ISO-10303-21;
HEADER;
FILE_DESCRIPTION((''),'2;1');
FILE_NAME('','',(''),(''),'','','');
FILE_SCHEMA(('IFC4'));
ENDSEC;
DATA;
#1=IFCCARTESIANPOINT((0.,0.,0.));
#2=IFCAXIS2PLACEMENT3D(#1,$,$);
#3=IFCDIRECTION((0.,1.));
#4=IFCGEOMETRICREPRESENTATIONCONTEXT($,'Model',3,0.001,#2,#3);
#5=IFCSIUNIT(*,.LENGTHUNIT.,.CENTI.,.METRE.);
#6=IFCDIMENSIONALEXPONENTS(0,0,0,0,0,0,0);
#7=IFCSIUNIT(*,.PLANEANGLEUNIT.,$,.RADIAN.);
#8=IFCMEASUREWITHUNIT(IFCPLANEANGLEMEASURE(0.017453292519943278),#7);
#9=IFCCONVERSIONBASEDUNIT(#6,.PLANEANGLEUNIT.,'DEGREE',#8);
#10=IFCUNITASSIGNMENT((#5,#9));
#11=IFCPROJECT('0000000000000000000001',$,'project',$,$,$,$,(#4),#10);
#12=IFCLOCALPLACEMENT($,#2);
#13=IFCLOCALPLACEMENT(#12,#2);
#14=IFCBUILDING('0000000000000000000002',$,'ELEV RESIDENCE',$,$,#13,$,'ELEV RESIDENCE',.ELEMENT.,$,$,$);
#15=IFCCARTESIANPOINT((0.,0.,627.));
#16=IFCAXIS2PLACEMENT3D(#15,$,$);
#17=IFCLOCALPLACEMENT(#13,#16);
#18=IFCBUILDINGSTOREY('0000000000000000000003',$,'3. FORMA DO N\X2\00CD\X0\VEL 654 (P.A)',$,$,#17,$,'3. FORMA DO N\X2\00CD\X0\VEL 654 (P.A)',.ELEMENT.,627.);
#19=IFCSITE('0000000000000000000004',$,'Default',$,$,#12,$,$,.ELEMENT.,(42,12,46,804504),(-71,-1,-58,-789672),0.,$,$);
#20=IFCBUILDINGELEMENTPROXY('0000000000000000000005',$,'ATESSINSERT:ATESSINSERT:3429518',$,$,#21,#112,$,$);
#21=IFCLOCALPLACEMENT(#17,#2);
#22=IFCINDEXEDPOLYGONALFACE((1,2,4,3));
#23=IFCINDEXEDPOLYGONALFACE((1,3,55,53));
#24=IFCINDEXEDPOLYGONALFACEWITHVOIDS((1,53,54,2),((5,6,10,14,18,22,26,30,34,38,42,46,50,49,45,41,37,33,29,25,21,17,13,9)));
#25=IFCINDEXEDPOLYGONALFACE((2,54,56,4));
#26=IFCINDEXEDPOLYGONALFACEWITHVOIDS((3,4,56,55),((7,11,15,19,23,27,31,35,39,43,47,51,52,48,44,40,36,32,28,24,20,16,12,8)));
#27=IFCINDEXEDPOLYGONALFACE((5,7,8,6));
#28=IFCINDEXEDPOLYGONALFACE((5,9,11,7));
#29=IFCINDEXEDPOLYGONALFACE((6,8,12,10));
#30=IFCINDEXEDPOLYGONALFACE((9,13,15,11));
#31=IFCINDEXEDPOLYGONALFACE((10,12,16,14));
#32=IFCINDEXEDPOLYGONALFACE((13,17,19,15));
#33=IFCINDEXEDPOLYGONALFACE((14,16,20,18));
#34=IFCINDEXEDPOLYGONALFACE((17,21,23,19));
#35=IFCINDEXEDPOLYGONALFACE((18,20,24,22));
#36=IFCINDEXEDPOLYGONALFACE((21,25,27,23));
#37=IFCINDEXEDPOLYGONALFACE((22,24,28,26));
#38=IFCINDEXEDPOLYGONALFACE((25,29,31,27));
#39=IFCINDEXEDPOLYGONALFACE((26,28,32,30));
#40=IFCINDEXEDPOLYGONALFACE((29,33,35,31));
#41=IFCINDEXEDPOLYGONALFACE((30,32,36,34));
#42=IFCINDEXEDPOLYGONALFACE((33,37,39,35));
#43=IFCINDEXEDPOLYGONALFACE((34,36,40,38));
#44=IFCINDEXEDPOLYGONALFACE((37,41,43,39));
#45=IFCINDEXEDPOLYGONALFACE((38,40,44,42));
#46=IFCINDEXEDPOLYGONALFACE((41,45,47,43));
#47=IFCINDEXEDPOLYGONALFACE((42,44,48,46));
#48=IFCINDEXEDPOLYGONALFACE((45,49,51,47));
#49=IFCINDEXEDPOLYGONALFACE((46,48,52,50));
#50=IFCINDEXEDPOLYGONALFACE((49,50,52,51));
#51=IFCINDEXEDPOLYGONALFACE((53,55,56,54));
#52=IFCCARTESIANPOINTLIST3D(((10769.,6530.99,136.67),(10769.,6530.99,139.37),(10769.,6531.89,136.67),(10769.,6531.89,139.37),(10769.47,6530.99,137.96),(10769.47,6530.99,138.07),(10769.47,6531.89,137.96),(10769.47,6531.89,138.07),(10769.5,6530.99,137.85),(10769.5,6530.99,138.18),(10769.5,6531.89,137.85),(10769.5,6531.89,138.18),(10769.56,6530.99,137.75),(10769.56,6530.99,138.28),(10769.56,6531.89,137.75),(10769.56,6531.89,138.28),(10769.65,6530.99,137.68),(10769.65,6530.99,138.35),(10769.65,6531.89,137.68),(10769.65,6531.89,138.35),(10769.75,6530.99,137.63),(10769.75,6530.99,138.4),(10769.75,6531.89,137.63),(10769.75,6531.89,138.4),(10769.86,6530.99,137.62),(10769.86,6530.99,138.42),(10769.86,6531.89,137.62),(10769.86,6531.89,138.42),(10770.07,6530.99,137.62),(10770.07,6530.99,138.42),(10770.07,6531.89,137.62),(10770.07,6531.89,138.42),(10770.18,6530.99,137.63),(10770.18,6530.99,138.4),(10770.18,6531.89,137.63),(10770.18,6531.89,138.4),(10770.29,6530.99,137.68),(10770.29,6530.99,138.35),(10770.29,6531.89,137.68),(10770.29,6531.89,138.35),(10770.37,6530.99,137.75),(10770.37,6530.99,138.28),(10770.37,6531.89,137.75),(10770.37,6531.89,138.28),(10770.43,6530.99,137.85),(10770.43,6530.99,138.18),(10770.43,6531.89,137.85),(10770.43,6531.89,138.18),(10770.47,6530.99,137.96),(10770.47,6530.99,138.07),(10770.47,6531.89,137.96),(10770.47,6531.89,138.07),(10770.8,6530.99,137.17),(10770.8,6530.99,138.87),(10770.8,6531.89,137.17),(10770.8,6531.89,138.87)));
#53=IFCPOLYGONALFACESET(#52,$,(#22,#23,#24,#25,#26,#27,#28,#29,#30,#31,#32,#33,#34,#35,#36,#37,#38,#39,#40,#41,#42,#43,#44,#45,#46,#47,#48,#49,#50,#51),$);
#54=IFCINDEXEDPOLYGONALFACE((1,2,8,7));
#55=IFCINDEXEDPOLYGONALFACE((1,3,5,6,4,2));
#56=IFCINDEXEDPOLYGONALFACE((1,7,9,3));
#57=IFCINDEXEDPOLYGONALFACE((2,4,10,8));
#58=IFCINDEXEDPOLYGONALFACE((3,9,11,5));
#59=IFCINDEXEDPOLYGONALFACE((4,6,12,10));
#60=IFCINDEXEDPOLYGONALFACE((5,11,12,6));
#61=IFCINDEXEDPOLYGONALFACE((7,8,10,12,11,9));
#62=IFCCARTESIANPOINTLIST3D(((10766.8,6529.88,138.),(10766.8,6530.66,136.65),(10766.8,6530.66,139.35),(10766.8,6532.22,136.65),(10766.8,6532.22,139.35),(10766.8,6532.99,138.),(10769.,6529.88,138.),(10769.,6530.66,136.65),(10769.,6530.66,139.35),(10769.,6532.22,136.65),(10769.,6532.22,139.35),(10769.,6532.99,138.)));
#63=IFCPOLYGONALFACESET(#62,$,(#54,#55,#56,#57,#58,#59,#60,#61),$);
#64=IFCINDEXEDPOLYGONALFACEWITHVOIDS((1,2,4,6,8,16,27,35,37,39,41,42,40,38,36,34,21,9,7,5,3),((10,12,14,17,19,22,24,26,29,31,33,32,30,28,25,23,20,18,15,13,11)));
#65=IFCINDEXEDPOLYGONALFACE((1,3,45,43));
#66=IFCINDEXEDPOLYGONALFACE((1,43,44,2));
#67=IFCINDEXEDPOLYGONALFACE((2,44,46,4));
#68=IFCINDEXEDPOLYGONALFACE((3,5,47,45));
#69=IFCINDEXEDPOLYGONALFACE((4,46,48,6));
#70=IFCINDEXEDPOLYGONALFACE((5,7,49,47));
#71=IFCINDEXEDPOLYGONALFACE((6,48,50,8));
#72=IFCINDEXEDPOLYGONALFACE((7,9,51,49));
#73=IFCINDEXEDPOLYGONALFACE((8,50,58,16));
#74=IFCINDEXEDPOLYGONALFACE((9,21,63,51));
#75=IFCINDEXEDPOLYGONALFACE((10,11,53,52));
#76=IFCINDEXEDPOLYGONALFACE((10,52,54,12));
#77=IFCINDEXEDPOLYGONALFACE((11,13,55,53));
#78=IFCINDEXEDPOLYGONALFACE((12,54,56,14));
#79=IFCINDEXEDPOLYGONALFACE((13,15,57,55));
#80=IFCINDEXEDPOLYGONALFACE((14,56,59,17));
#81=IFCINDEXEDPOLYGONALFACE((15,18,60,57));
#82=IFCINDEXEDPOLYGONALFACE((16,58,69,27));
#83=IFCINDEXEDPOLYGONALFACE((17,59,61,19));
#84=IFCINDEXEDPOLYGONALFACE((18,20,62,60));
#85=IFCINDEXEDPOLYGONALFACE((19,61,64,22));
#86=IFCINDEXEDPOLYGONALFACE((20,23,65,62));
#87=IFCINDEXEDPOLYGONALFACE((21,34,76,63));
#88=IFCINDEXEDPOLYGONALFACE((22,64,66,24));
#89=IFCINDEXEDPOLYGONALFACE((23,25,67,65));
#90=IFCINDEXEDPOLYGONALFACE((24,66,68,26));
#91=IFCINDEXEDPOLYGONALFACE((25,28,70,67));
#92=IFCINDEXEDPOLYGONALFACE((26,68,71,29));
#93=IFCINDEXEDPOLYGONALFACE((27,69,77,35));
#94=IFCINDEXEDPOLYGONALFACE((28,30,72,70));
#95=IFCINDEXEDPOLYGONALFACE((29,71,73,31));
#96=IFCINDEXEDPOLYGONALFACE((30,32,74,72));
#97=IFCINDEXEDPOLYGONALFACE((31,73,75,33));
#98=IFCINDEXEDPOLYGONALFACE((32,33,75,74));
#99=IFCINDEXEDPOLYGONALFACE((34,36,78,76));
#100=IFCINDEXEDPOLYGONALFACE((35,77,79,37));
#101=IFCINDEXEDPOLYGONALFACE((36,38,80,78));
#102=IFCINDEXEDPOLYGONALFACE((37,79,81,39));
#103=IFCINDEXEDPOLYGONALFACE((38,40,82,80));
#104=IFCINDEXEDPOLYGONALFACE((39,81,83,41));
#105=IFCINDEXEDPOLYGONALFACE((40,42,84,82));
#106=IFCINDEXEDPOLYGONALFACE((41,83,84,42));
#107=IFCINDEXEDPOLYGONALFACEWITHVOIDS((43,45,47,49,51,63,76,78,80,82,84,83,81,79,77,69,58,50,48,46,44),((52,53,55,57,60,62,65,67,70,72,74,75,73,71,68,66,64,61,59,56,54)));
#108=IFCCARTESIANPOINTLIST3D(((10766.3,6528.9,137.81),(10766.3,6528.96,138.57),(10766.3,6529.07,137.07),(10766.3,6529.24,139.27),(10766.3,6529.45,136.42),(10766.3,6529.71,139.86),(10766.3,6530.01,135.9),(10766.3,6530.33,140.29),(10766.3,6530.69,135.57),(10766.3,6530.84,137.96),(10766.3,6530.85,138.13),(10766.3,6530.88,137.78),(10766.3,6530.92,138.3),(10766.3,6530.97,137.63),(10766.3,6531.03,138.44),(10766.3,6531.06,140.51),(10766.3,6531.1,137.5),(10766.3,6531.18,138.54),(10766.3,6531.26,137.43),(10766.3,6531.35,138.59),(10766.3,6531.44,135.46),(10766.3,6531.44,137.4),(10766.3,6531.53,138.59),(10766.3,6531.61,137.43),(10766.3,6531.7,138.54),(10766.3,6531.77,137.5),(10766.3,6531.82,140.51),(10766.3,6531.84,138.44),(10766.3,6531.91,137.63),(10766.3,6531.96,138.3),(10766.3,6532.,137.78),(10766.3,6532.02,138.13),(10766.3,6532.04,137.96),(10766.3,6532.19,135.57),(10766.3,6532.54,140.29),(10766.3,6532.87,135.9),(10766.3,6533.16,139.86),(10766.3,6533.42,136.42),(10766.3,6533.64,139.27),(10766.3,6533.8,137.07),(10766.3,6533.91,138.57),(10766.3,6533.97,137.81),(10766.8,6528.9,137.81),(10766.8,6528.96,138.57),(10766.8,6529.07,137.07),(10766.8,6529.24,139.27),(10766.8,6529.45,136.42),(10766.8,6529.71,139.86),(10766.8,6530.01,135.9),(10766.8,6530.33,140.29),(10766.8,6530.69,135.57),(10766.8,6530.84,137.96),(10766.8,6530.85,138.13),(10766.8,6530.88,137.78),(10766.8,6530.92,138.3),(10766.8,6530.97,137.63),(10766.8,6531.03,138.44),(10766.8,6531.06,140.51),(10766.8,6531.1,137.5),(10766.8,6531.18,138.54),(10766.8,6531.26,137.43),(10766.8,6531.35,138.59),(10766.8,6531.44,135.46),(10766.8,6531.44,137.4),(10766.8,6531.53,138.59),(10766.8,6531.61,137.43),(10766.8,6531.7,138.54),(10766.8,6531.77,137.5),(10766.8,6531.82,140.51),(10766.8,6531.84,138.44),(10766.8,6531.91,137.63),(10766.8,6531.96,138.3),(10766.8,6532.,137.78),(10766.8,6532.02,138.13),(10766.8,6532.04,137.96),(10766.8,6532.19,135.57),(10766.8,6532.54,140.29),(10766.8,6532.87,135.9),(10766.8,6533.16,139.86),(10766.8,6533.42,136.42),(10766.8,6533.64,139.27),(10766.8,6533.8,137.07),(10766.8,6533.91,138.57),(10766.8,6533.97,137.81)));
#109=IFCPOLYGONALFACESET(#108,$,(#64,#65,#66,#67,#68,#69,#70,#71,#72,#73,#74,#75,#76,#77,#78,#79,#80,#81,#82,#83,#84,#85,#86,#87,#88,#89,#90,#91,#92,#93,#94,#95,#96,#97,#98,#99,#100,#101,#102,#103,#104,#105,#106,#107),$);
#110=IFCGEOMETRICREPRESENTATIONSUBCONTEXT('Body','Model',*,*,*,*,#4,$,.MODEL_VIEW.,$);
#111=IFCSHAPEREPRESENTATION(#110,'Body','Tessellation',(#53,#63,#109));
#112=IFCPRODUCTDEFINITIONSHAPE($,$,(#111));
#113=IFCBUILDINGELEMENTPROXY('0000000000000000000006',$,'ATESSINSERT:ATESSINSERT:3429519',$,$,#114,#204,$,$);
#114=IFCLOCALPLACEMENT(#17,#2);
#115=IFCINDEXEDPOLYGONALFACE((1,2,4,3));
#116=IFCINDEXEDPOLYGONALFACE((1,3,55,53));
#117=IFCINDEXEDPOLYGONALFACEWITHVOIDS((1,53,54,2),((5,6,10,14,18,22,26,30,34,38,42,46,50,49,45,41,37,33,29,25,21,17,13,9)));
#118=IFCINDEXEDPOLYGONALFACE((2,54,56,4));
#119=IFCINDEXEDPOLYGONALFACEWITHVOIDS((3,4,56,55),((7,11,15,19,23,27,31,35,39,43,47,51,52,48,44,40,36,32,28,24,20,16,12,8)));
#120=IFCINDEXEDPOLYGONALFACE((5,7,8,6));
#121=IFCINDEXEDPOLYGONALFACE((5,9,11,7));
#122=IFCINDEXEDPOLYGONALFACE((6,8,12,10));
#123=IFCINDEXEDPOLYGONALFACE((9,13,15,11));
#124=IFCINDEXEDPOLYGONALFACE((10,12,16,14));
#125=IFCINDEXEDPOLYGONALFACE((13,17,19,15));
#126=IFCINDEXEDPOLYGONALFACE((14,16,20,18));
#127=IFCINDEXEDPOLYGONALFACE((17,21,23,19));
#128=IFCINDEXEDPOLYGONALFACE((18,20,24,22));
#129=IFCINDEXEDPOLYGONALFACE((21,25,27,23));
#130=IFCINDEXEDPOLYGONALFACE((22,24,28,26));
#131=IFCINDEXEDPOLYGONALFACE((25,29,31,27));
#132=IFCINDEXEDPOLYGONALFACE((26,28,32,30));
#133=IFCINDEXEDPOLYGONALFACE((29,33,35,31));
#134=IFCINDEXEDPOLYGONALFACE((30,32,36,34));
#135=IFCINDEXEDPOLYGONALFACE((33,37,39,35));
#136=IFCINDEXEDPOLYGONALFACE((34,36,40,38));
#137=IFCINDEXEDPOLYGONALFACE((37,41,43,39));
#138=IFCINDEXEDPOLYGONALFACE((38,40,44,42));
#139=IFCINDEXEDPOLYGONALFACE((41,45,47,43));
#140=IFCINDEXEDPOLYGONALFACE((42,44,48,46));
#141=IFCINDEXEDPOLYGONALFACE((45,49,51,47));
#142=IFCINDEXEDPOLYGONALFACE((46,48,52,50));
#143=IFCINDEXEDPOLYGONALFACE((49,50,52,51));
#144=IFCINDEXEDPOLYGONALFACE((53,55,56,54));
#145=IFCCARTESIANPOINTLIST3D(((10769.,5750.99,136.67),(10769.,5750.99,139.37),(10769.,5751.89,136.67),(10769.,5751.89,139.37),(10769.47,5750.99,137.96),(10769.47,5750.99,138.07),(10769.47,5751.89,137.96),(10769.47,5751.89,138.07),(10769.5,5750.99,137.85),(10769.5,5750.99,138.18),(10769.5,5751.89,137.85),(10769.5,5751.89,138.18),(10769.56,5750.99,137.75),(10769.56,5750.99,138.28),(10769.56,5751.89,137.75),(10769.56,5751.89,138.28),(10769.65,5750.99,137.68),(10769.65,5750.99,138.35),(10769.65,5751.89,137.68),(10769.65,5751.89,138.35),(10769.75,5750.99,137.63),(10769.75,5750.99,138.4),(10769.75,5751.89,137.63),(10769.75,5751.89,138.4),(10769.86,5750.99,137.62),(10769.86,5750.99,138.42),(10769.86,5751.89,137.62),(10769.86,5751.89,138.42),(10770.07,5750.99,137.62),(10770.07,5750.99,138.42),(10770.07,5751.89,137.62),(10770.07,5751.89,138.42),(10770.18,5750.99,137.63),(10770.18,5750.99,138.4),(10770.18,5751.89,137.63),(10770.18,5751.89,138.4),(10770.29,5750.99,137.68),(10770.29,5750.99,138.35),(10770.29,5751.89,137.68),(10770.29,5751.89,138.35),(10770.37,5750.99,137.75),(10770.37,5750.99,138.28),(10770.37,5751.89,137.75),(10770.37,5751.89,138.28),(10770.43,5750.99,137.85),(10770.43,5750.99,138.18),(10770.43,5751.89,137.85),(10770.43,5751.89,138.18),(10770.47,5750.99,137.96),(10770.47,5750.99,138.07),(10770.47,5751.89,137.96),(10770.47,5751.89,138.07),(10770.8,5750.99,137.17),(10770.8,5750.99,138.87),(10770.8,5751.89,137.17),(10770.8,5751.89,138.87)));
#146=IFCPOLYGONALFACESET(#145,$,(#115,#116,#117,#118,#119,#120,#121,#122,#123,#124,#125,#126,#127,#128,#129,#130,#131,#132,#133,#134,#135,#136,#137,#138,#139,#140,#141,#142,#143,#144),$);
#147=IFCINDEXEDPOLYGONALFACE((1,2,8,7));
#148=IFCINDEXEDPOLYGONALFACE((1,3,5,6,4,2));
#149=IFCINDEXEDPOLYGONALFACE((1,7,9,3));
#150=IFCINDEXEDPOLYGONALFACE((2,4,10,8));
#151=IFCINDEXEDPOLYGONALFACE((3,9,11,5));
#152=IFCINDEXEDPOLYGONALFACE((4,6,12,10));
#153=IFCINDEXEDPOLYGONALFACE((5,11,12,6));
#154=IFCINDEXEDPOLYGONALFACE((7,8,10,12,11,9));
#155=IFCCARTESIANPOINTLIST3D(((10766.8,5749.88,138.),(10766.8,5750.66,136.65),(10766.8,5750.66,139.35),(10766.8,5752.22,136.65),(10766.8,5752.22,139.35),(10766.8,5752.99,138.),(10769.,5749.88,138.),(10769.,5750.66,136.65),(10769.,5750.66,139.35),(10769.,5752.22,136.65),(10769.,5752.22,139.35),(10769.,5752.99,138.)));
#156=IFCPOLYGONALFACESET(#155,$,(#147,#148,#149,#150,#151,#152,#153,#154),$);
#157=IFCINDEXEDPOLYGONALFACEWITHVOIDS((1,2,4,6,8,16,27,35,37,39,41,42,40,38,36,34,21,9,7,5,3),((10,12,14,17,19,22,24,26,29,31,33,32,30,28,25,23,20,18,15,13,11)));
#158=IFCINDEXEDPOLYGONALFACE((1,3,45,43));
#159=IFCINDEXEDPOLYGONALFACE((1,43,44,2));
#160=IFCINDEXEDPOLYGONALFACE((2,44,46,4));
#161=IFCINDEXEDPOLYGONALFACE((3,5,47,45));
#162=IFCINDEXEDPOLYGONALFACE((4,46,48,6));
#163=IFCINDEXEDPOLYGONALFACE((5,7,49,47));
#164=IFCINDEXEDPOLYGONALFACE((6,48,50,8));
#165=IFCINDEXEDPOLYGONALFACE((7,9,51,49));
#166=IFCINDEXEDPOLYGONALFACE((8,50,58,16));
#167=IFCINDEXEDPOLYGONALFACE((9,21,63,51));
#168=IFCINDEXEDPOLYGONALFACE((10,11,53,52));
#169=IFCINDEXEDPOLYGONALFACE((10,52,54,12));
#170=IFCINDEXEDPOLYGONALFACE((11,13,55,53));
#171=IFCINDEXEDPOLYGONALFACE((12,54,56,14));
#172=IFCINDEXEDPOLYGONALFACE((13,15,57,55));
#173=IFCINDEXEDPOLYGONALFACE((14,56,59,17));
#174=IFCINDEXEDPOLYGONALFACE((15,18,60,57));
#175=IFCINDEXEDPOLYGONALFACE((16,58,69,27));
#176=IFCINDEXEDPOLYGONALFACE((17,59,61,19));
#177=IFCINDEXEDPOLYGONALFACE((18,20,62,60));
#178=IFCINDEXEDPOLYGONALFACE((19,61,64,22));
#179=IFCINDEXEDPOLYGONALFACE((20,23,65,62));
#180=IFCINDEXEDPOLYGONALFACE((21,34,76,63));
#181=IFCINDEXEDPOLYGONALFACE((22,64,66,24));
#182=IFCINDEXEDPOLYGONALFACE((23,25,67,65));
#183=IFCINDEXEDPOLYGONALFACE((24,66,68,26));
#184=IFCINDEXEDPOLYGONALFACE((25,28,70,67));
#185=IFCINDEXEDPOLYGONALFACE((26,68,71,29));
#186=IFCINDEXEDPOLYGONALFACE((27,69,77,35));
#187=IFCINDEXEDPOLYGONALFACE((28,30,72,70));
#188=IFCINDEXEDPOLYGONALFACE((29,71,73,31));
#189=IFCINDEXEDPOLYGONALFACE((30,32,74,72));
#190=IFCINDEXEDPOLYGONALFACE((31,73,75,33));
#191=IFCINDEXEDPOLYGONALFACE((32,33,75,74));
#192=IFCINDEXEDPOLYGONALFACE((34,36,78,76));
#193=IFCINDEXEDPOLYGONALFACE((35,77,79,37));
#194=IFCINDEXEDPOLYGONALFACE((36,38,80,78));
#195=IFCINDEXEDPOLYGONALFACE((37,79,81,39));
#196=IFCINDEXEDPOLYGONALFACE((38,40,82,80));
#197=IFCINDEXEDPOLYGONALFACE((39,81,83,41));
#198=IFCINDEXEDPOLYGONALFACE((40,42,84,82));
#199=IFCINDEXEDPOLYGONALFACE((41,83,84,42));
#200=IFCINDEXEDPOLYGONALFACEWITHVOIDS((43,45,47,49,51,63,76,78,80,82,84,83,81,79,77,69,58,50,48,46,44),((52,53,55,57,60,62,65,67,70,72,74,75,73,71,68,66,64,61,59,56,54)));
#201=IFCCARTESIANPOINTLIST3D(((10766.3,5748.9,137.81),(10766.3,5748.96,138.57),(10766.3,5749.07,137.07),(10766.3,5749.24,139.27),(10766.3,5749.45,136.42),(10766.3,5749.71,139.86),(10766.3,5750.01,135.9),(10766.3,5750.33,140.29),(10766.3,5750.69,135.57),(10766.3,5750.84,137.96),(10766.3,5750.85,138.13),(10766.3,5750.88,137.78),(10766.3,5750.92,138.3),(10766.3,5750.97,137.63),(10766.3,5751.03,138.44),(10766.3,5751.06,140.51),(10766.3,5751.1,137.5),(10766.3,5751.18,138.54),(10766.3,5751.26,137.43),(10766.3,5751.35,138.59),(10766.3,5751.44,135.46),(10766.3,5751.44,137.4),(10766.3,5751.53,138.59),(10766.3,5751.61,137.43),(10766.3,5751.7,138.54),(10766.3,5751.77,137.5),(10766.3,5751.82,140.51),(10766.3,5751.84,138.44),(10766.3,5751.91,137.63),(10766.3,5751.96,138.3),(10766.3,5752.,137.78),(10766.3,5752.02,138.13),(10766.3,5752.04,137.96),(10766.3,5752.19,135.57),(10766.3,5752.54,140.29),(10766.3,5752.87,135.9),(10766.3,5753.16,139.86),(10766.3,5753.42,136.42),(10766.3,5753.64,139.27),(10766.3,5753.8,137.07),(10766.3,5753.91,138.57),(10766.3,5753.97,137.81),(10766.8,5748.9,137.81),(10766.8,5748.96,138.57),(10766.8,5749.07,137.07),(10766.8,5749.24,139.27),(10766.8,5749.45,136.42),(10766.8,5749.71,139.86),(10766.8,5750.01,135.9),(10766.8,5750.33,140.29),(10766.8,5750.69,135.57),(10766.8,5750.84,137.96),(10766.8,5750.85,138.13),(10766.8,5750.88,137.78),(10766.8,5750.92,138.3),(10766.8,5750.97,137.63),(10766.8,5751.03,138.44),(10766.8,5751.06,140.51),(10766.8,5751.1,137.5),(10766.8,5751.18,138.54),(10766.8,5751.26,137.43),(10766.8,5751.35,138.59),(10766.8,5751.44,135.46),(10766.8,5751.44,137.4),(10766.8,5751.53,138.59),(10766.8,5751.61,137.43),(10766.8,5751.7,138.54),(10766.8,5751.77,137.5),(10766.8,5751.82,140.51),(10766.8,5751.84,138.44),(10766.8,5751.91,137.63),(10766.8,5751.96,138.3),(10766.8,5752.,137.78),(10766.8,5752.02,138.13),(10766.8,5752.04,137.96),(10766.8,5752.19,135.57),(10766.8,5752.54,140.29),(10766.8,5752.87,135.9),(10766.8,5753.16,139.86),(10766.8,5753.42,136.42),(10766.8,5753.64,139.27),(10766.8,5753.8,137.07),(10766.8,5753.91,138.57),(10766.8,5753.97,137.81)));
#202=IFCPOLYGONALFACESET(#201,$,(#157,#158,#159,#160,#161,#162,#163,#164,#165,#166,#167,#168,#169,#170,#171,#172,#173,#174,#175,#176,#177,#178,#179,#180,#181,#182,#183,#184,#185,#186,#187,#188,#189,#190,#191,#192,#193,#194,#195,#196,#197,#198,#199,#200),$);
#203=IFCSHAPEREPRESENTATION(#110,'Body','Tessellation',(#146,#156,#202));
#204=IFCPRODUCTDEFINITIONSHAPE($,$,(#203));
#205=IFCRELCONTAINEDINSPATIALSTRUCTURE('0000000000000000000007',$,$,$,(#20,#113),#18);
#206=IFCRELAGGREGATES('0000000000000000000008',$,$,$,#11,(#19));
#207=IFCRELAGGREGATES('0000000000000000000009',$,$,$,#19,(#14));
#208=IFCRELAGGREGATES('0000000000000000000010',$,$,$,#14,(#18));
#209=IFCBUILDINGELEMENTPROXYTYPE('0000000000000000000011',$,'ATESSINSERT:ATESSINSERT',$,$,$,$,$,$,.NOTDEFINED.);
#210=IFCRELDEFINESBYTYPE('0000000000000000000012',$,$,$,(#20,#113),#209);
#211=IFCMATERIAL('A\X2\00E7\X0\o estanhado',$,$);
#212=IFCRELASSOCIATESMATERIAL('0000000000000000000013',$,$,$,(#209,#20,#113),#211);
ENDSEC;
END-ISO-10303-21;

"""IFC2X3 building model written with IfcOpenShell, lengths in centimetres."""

from ifc_helpers import new_model, entity, si_unit, converted_unit, direction, frame, frame_2d, origin, place, context, subcontext, project, spatial, polyline, circle_curve, parameter, trimmed, segment, composite_curve, hollow_circle, outline, extrude, source, transform, mapped, material, type_object, type_shapes, element, save


model = new_model("IFC2X3")

# Units and contexts
model_context = context("Model", 3, precision=0.001, world=origin(), true_north=direction((0.0, 1.0)))
body_context = subcontext(model_context, "Body", "Model", "MODEL_VIEW")
ifc_project = project(units=[si_unit("LENGTHUNIT", "METRE", prefix="CENTI"), converted_unit("PLANEANGLEUNIT", "DEGREE", entity("IfcPlaneAngleMeasure", 0.017453292519943278), si_unit("PLANEANGLEUNIT", "RADIAN"), dimensions=[0, 0, 0, 0, 0, 0, 0])], contexts=[model_context])

# Site, building, storey
site_placement = place(None, origin())
site = spatial("IfcSite", under=ifc_project, at=site_placement, Name="Default", CompositionType="ELEMENT", RefLatitude=(42, 12, 46, 804504), RefLongitude=(-71, -1, -58, -789672), RefElevation=0.0)
building_placement = place(site_placement, origin())
building = spatial("IfcBuilding", under=site, at=building_placement, Name="ELEV RESIDENCE", LongName="ELEV RESIDENCE", CompositionType="ELEMENT")
storey_placement = place(building_placement, frame((0.0, 0.0, 627.0)))
storey = spatial("IfcBuildingStorey", under=building, at=storey_placement, Name="3. FORMA DO NÍVEL 654 (P.A)", LongName="3. FORMA DO NÍVEL 654 (P.A)", CompositionType="ELEMENT", Elevation=627.0)

# Building element proxies
ifc_material_1 = material(Name="Aço estanhado")
building_element_proxy_type_1 = type_object("IfcBuildingElementProxyType", Name="ATESSINSERT:ATESSINSERT", PredefinedType="NOTDEFINED", material=ifc_material_1)
shared_shape_1 = source(origin(), body_context, "Body", "SweptSolid", [
    extrude(outline(polyline([(-1.35, -0.9), (1.35, -0.9), (0.85, 0.9), (-0.85, 0.9), (-1.35, -0.9)]), holes=[composite_curve([segment(trimmed(circle_curve(frame_2d((0.0, 0.17), x_axis=(1.0, 0.0)), 0.4), [parameter(0.0)], [parameter(180.0)], True, "PARAMETER"), False, "CONTINUOUS"), segment(polyline([(0.4, 0.17), (0.4, -0.03)]), True, "CONTINUOUS"), segment(trimmed(circle_curve(frame_2d((0.0, -0.03), x_axis=(1.0, 0.0)), 0.4), [parameter(180.0)], [parameter(0.0)], True, "PARAMETER"), False, "CONTINUOUS"), segment(polyline([(-0.4, -0.03), (-0.4, 0.17)]), True, "CONTINUOUS")], self_intersect=False)]), frame((-1.4, -0.45, 30.02), z_axis=(0.0, 1.0, 0.0), x_axis=(0.0, 0.0, 1.0)), (0.0, 0.0, 1.0), 0.9),
    extrude(outline(polyline([(-0.78, -1.35), (0.78, -1.35), (1.56, 0.0), (0.78, 1.35), (-0.78, 1.35), (-1.56, 0.0), (-0.78, -1.35)])), frame((-4.5, 0.0, 30.0), z_axis=(1.0, 0.0, 0.0), x_axis=(0.0, 1.0, 0.0)), (0.0, 0.0, 1.0), 2.2),
    extrude(hollow_circle(Radius=2.54, WallThickness=1.94, at=frame_2d((0.0, 0.0), x_axis=(1.0, 0.0))), frame((-5.0, 0.0, 30.0), z_axis=(1.0, 0.0, 0.0), x_axis=(0.0, 0.0, -1.0)), (0.0, 0.0, 1.0), 0.5),
])
type_shapes(building_element_proxy_type_1, [shared_shape_1])
for number, where, name in (
    (1, (10771.3, 6531.44, 108.0), "ATESSINSERT:ATESSINSERT:3429518"),
    (2, (10771.3, 5751.44, 108.0), "ATESSINSERT:ATESSINSERT:3429519"),
):
    element("IfcBuildingElementProxy", number, at=place(storey_placement, frame(where)), inside=storey, type_object=building_element_proxy_type_1, material=ifc_material_1, Name=name, context=body_context, shape_type="MappedRepresentation", body=[
        mapped(shared_shape_1, transform((0.0, 0.0, 0.0), scale=1.0)),
    ])

save(model, "model.ifc")
